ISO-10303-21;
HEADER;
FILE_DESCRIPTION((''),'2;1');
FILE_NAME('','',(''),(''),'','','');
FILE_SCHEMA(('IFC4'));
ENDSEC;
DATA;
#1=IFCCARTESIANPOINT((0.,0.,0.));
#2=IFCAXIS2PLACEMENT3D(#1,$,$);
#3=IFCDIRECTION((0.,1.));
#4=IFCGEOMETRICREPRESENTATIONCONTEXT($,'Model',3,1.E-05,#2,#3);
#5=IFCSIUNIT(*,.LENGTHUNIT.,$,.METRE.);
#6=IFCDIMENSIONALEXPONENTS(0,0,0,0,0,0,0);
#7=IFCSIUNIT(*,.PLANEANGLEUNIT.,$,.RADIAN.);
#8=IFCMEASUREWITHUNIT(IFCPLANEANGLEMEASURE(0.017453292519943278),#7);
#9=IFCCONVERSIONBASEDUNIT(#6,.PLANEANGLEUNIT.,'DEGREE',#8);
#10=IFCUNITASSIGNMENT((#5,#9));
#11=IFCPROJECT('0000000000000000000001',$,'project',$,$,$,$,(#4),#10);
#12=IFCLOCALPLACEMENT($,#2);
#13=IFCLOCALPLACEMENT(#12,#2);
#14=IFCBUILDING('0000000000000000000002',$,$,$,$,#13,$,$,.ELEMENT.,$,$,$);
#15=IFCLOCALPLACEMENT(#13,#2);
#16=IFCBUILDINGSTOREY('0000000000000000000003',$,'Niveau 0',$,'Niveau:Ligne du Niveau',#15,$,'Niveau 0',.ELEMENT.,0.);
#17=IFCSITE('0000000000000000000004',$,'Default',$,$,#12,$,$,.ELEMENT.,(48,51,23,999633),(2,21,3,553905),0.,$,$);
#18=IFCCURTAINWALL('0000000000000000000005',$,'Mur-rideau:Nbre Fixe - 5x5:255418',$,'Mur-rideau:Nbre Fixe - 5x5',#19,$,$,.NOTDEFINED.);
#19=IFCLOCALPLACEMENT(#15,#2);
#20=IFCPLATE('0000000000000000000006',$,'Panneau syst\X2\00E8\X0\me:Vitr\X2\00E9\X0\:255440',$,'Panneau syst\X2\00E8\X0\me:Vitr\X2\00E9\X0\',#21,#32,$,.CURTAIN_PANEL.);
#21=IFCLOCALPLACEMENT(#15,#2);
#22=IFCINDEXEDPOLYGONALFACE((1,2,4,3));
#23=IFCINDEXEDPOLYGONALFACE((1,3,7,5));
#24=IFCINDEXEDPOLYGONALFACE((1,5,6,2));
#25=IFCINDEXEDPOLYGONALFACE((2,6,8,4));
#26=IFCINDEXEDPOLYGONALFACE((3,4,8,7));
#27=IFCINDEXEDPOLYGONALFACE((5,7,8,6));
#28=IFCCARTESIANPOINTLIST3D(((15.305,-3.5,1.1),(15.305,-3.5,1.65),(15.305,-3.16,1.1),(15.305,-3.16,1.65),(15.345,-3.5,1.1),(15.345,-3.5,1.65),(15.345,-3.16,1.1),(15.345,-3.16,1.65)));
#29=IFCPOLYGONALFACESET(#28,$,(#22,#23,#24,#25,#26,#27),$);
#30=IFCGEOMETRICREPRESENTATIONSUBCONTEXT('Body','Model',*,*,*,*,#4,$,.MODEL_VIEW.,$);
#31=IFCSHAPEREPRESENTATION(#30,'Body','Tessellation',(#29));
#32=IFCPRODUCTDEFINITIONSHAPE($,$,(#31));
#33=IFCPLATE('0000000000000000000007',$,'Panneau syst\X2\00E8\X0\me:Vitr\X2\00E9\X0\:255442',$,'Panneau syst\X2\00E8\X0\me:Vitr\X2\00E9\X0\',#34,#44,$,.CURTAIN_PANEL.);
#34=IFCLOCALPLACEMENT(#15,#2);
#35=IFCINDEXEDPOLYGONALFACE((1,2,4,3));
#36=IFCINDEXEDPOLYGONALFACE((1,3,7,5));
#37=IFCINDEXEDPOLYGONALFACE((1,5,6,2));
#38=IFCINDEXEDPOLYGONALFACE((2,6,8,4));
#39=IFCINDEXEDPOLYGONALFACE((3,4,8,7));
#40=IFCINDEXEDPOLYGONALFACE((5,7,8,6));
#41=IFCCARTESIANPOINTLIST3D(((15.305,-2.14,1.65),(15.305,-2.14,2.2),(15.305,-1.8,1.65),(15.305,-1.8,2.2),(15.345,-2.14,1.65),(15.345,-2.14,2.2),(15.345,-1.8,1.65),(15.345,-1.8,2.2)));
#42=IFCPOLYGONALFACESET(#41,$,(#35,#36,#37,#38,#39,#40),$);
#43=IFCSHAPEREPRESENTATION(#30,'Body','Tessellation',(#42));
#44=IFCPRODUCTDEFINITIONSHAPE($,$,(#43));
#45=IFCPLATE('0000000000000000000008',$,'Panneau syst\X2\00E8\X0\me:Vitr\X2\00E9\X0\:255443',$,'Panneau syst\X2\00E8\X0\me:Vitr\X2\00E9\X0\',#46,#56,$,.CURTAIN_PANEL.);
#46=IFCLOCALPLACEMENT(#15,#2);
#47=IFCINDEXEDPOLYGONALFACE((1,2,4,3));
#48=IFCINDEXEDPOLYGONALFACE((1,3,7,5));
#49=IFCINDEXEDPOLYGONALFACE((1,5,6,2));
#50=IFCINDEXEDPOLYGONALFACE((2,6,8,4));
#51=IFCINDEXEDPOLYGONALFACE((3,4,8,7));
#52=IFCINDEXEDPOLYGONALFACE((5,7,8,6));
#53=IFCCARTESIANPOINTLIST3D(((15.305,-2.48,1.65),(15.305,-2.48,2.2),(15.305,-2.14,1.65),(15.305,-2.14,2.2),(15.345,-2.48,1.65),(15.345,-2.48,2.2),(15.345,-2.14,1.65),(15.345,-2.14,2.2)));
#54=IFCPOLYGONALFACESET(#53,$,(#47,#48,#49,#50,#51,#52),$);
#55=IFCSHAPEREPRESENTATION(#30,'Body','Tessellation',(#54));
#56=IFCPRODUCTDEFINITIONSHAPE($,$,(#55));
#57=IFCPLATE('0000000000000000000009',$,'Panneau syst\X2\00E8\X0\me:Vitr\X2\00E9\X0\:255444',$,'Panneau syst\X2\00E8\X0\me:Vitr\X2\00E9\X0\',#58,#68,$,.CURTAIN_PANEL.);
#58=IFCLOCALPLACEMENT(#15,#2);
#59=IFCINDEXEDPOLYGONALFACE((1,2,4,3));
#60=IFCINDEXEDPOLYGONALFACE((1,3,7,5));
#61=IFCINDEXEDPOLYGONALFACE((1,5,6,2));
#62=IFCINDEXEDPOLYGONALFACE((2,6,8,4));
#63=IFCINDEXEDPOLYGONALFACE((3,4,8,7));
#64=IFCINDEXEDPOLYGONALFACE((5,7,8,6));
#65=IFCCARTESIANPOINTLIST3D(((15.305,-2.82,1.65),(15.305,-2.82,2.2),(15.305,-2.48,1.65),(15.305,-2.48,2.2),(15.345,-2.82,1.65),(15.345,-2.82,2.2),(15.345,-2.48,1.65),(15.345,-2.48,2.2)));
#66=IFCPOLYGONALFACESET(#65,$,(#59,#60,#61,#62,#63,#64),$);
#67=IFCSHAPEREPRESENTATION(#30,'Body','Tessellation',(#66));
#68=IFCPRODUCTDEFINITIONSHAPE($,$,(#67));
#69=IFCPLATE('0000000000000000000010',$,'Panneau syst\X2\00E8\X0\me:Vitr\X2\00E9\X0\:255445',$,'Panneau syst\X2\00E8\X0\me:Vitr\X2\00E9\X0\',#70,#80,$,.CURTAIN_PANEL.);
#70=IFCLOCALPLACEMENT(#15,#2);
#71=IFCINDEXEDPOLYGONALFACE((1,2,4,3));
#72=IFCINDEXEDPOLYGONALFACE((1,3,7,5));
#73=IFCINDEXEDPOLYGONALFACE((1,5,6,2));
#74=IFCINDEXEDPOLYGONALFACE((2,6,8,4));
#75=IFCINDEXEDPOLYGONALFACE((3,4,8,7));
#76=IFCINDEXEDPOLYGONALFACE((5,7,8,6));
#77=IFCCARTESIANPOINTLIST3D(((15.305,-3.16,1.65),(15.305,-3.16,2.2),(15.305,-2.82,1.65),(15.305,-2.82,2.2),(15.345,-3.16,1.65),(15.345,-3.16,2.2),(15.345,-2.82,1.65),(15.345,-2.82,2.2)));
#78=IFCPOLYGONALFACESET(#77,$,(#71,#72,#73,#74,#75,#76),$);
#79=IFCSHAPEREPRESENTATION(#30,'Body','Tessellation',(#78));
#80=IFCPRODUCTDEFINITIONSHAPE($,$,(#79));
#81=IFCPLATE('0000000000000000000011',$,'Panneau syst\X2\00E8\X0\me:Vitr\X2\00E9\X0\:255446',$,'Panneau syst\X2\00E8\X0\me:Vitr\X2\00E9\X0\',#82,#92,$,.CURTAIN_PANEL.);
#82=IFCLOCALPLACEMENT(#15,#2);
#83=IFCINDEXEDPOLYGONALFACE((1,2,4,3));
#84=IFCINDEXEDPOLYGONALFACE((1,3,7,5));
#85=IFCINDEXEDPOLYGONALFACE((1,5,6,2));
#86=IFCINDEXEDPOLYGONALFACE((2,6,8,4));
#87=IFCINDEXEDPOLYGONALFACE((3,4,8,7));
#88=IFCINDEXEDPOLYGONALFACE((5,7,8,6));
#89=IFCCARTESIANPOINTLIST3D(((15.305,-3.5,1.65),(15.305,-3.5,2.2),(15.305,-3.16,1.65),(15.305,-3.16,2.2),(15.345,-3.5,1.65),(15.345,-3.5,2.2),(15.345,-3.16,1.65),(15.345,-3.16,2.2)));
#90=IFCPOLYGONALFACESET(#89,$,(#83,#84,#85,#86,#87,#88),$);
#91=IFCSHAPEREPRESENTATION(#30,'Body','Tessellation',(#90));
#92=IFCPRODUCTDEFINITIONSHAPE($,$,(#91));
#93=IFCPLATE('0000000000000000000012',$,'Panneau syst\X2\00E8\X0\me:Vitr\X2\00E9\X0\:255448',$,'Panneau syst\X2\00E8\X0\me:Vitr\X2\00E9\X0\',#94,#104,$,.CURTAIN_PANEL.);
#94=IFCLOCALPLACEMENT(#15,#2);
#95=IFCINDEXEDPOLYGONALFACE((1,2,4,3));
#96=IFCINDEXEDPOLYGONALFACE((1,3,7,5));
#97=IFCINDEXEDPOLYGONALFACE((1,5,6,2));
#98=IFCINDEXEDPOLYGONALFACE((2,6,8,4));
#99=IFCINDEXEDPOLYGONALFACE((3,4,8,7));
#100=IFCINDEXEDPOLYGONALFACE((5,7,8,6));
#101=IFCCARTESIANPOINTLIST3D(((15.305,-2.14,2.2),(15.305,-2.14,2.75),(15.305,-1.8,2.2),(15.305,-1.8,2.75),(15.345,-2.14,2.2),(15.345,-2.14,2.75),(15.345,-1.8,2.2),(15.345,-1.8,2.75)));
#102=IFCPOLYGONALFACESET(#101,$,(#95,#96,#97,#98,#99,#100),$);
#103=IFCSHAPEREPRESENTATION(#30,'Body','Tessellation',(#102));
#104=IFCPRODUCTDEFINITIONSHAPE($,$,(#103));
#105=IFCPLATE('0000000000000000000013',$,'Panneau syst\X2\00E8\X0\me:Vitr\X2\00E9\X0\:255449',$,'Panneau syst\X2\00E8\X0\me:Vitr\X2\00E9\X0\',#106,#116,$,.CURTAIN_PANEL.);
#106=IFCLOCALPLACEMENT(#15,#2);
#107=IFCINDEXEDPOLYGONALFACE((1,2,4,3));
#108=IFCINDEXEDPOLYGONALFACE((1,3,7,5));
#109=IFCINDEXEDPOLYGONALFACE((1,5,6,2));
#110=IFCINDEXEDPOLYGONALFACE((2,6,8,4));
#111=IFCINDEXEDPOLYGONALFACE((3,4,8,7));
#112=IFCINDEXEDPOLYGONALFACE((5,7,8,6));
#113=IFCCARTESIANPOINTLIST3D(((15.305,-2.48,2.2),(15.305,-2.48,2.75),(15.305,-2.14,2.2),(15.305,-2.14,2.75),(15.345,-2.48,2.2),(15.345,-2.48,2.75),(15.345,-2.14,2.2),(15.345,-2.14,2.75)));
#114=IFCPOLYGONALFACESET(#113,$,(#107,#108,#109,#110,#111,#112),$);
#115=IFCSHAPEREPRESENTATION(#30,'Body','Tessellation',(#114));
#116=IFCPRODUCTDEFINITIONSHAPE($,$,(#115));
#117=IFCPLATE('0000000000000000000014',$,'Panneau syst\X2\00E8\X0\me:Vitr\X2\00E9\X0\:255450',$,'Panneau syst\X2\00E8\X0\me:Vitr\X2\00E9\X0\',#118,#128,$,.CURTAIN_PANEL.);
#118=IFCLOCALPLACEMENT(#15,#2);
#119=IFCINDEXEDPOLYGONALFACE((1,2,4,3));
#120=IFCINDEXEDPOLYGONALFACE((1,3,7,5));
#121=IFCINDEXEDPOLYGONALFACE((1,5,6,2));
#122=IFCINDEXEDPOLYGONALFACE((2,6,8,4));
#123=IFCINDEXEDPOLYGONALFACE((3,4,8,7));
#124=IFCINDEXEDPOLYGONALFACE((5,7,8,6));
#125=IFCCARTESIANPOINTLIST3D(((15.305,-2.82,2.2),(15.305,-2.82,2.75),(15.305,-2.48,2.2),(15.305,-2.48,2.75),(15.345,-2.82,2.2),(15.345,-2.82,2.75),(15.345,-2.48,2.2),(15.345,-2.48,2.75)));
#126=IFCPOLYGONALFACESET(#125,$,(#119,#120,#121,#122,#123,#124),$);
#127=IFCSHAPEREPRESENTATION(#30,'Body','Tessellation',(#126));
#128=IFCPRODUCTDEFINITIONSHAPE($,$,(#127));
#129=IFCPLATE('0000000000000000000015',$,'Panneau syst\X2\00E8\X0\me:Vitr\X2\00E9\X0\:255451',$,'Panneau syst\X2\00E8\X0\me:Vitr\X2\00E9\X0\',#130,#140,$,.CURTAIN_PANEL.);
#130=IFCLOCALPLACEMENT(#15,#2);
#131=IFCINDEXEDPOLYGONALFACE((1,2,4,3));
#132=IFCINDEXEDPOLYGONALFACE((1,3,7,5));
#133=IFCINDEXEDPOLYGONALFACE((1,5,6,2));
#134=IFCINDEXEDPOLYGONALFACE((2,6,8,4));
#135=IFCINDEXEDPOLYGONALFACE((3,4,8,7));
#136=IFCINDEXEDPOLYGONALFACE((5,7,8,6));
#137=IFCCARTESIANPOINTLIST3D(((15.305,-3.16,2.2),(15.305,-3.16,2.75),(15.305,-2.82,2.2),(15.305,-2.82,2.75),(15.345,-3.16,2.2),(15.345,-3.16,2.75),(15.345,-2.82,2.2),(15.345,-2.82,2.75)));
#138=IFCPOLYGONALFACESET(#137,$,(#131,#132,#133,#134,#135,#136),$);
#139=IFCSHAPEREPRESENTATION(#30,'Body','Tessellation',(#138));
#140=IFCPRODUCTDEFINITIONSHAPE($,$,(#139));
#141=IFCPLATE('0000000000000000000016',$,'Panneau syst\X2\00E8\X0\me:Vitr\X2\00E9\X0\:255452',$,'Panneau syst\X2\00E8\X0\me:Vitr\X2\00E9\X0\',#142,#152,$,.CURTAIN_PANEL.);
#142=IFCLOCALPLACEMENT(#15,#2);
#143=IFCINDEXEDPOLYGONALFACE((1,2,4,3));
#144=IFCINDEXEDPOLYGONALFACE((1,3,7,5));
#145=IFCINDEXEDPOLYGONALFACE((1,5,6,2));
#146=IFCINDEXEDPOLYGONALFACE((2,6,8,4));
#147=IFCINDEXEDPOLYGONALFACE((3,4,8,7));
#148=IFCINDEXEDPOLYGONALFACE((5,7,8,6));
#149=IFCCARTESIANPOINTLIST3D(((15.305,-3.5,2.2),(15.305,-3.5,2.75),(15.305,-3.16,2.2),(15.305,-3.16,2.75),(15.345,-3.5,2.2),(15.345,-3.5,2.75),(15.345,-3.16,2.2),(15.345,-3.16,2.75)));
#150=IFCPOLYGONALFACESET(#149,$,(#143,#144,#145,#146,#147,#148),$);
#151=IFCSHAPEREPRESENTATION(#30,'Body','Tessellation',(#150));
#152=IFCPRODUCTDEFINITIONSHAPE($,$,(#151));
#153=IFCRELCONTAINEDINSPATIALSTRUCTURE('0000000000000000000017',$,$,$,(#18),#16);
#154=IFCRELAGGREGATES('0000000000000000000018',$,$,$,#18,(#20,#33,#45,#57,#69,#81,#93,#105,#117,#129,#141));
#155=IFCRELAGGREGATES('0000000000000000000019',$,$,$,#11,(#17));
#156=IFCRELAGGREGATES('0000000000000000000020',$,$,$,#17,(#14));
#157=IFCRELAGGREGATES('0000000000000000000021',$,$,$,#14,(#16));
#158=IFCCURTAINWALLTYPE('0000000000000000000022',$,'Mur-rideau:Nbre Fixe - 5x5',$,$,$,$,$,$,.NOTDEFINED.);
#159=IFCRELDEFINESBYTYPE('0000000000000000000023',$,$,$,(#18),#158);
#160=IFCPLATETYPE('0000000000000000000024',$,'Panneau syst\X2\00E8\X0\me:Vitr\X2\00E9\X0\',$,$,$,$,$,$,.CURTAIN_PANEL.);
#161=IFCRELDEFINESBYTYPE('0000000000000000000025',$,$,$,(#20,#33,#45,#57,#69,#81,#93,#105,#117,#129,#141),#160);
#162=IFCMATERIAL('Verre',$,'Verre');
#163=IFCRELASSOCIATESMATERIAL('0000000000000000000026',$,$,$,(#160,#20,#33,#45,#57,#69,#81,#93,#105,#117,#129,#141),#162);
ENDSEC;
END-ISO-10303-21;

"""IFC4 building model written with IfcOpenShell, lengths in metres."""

from ifc_helpers import new_model, entity, si_unit, converted_unit, direction, frame, origin, place, context, subcontext, project, spatial, indexed_curve, outline, extrude, source, transform, mapped, material, type_object, type_shapes, element, aggregate, save


model = new_model("IFC4")

# Units and contexts
model_context = context("Model", 3, precision=1e-05, world=origin(), true_north=direction((0.0, 1.0)))
body_context = subcontext(model_context, "Body", "Model", "MODEL_VIEW")
ifc_project = project(units=[si_unit("LENGTHUNIT", "METRE"), converted_unit("PLANEANGLEUNIT", "DEGREE", entity("IfcPlaneAngleMeasure", 0.017453292519943278), si_unit("PLANEANGLEUNIT", "RADIAN"), dimensions=[0, 0, 0, 0, 0, 0, 0])], contexts=[model_context])

# Site, building, storey
site_placement = place(None, origin())
site = spatial("IfcSite", under=ifc_project, at=site_placement, Name="Default", CompositionType="ELEMENT", RefLatitude=(48, 51, 23, 999633), RefLongitude=(2, 21, 3, 553905), RefElevation=0.0)
building_placement = place(site_placement, origin())
building = spatial("IfcBuilding", under=site, at=building_placement, CompositionType="ELEMENT")
storey_placement = place(building_placement, origin())
storey = spatial("IfcBuildingStorey", under=building, at=storey_placement, Name="Niveau 0", ObjectType="Niveau:Ligne du Niveau", LongName="Niveau 0", CompositionType="ELEMENT", Elevation=0.0)

# Shared definitions
curtain_wall_type = type_object("IfcCurtainWallType", Name="Mur-rideau:Nbre Fixe - 5x5", PredefinedType="NOTDEFINED")
ifc_material = material(Name="Verre", Category="Verre")

# Curtain wall, plates
curtain_wall_1_placement = place(storey_placement, origin())
curtain_wall_1 = element("IfcCurtainWall", 1, at=curtain_wall_1_placement, inside=storey, type_object=curtain_wall_type, Name="Mur-rideau:Nbre Fixe - 5x5:255418", ObjectType="Mur-rideau:Nbre Fixe - 5x5", PredefinedType="NOTDEFINED")
plate_type_1 = type_object("IfcPlateType", Name="Panneau système:Vitré", PredefinedType="CURTAIN_PANEL", material=ifc_material)
shared_shape_1 = source(origin(), body_context, "Body", "SweptSolid", [
    extrude(outline(indexed_curve([(-0.02, -0.17), (0.02, -0.17), (0.02, 0.17), (-0.02, 0.17), (-0.02, -0.17)], self_intersect=False)), frame((0.17, 0.02, 0.0), z_axis=(0.0, 0.0, 1.0), x_axis=(0.0, 1.0, 0.0)), (0.0, 0.0, 1.0), 0.55),
])
type_shapes(plate_type_1, [shared_shape_1])
plate_1_placement = place(curtain_wall_1_placement, frame((15.305, -3.16, 1.1), z_axis=(0.0, 0.0, 1.0), x_axis=(0.0, -1.0, 0.0)))
plate_1 = element("IfcPlate", 2, at=plate_1_placement, type_object=plate_type_1, material=ifc_material, Name="Panneau système:Vitré:255440", ObjectType="Panneau système:Vitré", PredefinedType="CURTAIN_PANEL", context=body_context, shape_type="MappedRepresentation", body=[
    mapped(shared_shape_1, transform((0.0, 0.0, 0.0), scale=1.0)),
])
plate_2_placement = place(curtain_wall_1_placement, frame((15.305, -1.8, 1.65), z_axis=(0.0, 0.0, 1.0), x_axis=(0.0, -1.0, 0.0)))
plate_2 = element("IfcPlate", 3, at=plate_2_placement, type_object=plate_type_1, material=ifc_material, Name="Panneau système:Vitré:255442", ObjectType="Panneau système:Vitré", PredefinedType="CURTAIN_PANEL", context=body_context, shape_type="MappedRepresentation", body=[
    mapped(shared_shape_1, transform((0.0, 0.0, 0.0), scale=1.0)),
])
plate_3_placement = place(curtain_wall_1_placement, frame((15.305, -2.14, 1.65), z_axis=(0.0, 0.0, 1.0), x_axis=(0.0, -1.0, 0.0)))
plate_3 = element("IfcPlate", 4, at=plate_3_placement, type_object=plate_type_1, material=ifc_material, Name="Panneau système:Vitré:255443", ObjectType="Panneau système:Vitré", PredefinedType="CURTAIN_PANEL", context=body_context, shape_type="MappedRepresentation", body=[
    mapped(shared_shape_1, transform((0.0, 0.0, 0.0), scale=1.0)),
])
plate_4_placement = place(curtain_wall_1_placement, frame((15.305, -2.48, 1.65), z_axis=(0.0, 0.0, 1.0), x_axis=(0.0, -1.0, 0.0)))
plate_4 = element("IfcPlate", 5, at=plate_4_placement, type_object=plate_type_1, material=ifc_material, Name="Panneau système:Vitré:255444", ObjectType="Panneau système:Vitré", PredefinedType="CURTAIN_PANEL", context=body_context, shape_type="MappedRepresentation", body=[
    mapped(shared_shape_1, transform((0.0, 0.0, 0.0), scale=1.0)),
])
plate_5_placement = place(curtain_wall_1_placement, frame((15.305, -2.82, 1.65), z_axis=(0.0, 0.0, 1.0), x_axis=(0.0, -1.0, 0.0)))
plate_5 = element("IfcPlate", 6, at=plate_5_placement, type_object=plate_type_1, material=ifc_material, Name="Panneau système:Vitré:255445", ObjectType="Panneau système:Vitré", PredefinedType="CURTAIN_PANEL", context=body_context, shape_type="MappedRepresentation", body=[
    mapped(shared_shape_1, transform((0.0, 0.0, 0.0), scale=1.0)),
])
plate_6_placement = place(curtain_wall_1_placement, frame((15.305, -3.16, 1.65), z_axis=(0.0, 0.0, 1.0), x_axis=(0.0, -1.0, 0.0)))
plate_6 = element("IfcPlate", 7, at=plate_6_placement, type_object=plate_type_1, material=ifc_material, Name="Panneau système:Vitré:255446", ObjectType="Panneau système:Vitré", PredefinedType="CURTAIN_PANEL", context=body_context, shape_type="MappedRepresentation", body=[
    mapped(shared_shape_1, transform((0.0, 0.0, 0.0), scale=1.0)),
])
plate_7_placement = place(curtain_wall_1_placement, frame((15.305, -1.8, 2.2), z_axis=(0.0, 0.0, 1.0), x_axis=(0.0, -1.0, 0.0)))
plate_7 = element("IfcPlate", 8, at=plate_7_placement, type_object=plate_type_1, material=ifc_material, Name="Panneau système:Vitré:255448", ObjectType="Panneau système:Vitré", PredefinedType="CURTAIN_PANEL", context=body_context, shape_type="MappedRepresentation", body=[
    mapped(shared_shape_1, transform((0.0, 0.0, 0.0), scale=1.0)),
])
plate_8_placement = place(curtain_wall_1_placement, frame((15.305, -2.14, 2.2), z_axis=(0.0, 0.0, 1.0), x_axis=(0.0, -1.0, 0.0)))
plate_8 = element("IfcPlate", 9, at=plate_8_placement, type_object=plate_type_1, material=ifc_material, Name="Panneau système:Vitré:255449", ObjectType="Panneau système:Vitré", PredefinedType="CURTAIN_PANEL", context=body_context, shape_type="MappedRepresentation", body=[
    mapped(shared_shape_1, transform((0.0, 0.0, 0.0), scale=1.0)),
])
plate_9_placement = place(curtain_wall_1_placement, frame((15.305, -2.48, 2.2), z_axis=(0.0, 0.0, 1.0), x_axis=(0.0, -1.0, 0.0)))
plate_9 = element("IfcPlate", 10, at=plate_9_placement, type_object=plate_type_1, material=ifc_material, Name="Panneau système:Vitré:255450", ObjectType="Panneau système:Vitré", PredefinedType="CURTAIN_PANEL", context=body_context, shape_type="MappedRepresentation", body=[
    mapped(shared_shape_1, transform((0.0, 0.0, 0.0), scale=1.0)),
])
plate_10_placement = place(curtain_wall_1_placement, frame((15.305, -2.82, 2.2), z_axis=(0.0, 0.0, 1.0), x_axis=(0.0, -1.0, 0.0)))
plate_10 = element("IfcPlate", 11, at=plate_10_placement, type_object=plate_type_1, material=ifc_material, Name="Panneau système:Vitré:255451", ObjectType="Panneau système:Vitré", PredefinedType="CURTAIN_PANEL", context=body_context, shape_type="MappedRepresentation", body=[
    mapped(shared_shape_1, transform((0.0, 0.0, 0.0), scale=1.0)),
])
plate_11_placement = place(curtain_wall_1_placement, frame((15.305, -3.16, 2.2), z_axis=(0.0, 0.0, 1.0), x_axis=(0.0, -1.0, 0.0)))
plate_11 = element("IfcPlate", 12, at=plate_11_placement, type_object=plate_type_1, material=ifc_material, Name="Panneau système:Vitré:255452", ObjectType="Panneau système:Vitré", PredefinedType="CURTAIN_PANEL", context=body_context, shape_type="MappedRepresentation", body=[
    mapped(shared_shape_1, transform((0.0, 0.0, 0.0), scale=1.0)),
])
aggregate(curtain_wall_1, [plate_1, plate_2, plate_3, plate_4, plate_5, plate_6, plate_7, plate_8, plate_9, plate_10, plate_11])

save(model, "model.ifc")
